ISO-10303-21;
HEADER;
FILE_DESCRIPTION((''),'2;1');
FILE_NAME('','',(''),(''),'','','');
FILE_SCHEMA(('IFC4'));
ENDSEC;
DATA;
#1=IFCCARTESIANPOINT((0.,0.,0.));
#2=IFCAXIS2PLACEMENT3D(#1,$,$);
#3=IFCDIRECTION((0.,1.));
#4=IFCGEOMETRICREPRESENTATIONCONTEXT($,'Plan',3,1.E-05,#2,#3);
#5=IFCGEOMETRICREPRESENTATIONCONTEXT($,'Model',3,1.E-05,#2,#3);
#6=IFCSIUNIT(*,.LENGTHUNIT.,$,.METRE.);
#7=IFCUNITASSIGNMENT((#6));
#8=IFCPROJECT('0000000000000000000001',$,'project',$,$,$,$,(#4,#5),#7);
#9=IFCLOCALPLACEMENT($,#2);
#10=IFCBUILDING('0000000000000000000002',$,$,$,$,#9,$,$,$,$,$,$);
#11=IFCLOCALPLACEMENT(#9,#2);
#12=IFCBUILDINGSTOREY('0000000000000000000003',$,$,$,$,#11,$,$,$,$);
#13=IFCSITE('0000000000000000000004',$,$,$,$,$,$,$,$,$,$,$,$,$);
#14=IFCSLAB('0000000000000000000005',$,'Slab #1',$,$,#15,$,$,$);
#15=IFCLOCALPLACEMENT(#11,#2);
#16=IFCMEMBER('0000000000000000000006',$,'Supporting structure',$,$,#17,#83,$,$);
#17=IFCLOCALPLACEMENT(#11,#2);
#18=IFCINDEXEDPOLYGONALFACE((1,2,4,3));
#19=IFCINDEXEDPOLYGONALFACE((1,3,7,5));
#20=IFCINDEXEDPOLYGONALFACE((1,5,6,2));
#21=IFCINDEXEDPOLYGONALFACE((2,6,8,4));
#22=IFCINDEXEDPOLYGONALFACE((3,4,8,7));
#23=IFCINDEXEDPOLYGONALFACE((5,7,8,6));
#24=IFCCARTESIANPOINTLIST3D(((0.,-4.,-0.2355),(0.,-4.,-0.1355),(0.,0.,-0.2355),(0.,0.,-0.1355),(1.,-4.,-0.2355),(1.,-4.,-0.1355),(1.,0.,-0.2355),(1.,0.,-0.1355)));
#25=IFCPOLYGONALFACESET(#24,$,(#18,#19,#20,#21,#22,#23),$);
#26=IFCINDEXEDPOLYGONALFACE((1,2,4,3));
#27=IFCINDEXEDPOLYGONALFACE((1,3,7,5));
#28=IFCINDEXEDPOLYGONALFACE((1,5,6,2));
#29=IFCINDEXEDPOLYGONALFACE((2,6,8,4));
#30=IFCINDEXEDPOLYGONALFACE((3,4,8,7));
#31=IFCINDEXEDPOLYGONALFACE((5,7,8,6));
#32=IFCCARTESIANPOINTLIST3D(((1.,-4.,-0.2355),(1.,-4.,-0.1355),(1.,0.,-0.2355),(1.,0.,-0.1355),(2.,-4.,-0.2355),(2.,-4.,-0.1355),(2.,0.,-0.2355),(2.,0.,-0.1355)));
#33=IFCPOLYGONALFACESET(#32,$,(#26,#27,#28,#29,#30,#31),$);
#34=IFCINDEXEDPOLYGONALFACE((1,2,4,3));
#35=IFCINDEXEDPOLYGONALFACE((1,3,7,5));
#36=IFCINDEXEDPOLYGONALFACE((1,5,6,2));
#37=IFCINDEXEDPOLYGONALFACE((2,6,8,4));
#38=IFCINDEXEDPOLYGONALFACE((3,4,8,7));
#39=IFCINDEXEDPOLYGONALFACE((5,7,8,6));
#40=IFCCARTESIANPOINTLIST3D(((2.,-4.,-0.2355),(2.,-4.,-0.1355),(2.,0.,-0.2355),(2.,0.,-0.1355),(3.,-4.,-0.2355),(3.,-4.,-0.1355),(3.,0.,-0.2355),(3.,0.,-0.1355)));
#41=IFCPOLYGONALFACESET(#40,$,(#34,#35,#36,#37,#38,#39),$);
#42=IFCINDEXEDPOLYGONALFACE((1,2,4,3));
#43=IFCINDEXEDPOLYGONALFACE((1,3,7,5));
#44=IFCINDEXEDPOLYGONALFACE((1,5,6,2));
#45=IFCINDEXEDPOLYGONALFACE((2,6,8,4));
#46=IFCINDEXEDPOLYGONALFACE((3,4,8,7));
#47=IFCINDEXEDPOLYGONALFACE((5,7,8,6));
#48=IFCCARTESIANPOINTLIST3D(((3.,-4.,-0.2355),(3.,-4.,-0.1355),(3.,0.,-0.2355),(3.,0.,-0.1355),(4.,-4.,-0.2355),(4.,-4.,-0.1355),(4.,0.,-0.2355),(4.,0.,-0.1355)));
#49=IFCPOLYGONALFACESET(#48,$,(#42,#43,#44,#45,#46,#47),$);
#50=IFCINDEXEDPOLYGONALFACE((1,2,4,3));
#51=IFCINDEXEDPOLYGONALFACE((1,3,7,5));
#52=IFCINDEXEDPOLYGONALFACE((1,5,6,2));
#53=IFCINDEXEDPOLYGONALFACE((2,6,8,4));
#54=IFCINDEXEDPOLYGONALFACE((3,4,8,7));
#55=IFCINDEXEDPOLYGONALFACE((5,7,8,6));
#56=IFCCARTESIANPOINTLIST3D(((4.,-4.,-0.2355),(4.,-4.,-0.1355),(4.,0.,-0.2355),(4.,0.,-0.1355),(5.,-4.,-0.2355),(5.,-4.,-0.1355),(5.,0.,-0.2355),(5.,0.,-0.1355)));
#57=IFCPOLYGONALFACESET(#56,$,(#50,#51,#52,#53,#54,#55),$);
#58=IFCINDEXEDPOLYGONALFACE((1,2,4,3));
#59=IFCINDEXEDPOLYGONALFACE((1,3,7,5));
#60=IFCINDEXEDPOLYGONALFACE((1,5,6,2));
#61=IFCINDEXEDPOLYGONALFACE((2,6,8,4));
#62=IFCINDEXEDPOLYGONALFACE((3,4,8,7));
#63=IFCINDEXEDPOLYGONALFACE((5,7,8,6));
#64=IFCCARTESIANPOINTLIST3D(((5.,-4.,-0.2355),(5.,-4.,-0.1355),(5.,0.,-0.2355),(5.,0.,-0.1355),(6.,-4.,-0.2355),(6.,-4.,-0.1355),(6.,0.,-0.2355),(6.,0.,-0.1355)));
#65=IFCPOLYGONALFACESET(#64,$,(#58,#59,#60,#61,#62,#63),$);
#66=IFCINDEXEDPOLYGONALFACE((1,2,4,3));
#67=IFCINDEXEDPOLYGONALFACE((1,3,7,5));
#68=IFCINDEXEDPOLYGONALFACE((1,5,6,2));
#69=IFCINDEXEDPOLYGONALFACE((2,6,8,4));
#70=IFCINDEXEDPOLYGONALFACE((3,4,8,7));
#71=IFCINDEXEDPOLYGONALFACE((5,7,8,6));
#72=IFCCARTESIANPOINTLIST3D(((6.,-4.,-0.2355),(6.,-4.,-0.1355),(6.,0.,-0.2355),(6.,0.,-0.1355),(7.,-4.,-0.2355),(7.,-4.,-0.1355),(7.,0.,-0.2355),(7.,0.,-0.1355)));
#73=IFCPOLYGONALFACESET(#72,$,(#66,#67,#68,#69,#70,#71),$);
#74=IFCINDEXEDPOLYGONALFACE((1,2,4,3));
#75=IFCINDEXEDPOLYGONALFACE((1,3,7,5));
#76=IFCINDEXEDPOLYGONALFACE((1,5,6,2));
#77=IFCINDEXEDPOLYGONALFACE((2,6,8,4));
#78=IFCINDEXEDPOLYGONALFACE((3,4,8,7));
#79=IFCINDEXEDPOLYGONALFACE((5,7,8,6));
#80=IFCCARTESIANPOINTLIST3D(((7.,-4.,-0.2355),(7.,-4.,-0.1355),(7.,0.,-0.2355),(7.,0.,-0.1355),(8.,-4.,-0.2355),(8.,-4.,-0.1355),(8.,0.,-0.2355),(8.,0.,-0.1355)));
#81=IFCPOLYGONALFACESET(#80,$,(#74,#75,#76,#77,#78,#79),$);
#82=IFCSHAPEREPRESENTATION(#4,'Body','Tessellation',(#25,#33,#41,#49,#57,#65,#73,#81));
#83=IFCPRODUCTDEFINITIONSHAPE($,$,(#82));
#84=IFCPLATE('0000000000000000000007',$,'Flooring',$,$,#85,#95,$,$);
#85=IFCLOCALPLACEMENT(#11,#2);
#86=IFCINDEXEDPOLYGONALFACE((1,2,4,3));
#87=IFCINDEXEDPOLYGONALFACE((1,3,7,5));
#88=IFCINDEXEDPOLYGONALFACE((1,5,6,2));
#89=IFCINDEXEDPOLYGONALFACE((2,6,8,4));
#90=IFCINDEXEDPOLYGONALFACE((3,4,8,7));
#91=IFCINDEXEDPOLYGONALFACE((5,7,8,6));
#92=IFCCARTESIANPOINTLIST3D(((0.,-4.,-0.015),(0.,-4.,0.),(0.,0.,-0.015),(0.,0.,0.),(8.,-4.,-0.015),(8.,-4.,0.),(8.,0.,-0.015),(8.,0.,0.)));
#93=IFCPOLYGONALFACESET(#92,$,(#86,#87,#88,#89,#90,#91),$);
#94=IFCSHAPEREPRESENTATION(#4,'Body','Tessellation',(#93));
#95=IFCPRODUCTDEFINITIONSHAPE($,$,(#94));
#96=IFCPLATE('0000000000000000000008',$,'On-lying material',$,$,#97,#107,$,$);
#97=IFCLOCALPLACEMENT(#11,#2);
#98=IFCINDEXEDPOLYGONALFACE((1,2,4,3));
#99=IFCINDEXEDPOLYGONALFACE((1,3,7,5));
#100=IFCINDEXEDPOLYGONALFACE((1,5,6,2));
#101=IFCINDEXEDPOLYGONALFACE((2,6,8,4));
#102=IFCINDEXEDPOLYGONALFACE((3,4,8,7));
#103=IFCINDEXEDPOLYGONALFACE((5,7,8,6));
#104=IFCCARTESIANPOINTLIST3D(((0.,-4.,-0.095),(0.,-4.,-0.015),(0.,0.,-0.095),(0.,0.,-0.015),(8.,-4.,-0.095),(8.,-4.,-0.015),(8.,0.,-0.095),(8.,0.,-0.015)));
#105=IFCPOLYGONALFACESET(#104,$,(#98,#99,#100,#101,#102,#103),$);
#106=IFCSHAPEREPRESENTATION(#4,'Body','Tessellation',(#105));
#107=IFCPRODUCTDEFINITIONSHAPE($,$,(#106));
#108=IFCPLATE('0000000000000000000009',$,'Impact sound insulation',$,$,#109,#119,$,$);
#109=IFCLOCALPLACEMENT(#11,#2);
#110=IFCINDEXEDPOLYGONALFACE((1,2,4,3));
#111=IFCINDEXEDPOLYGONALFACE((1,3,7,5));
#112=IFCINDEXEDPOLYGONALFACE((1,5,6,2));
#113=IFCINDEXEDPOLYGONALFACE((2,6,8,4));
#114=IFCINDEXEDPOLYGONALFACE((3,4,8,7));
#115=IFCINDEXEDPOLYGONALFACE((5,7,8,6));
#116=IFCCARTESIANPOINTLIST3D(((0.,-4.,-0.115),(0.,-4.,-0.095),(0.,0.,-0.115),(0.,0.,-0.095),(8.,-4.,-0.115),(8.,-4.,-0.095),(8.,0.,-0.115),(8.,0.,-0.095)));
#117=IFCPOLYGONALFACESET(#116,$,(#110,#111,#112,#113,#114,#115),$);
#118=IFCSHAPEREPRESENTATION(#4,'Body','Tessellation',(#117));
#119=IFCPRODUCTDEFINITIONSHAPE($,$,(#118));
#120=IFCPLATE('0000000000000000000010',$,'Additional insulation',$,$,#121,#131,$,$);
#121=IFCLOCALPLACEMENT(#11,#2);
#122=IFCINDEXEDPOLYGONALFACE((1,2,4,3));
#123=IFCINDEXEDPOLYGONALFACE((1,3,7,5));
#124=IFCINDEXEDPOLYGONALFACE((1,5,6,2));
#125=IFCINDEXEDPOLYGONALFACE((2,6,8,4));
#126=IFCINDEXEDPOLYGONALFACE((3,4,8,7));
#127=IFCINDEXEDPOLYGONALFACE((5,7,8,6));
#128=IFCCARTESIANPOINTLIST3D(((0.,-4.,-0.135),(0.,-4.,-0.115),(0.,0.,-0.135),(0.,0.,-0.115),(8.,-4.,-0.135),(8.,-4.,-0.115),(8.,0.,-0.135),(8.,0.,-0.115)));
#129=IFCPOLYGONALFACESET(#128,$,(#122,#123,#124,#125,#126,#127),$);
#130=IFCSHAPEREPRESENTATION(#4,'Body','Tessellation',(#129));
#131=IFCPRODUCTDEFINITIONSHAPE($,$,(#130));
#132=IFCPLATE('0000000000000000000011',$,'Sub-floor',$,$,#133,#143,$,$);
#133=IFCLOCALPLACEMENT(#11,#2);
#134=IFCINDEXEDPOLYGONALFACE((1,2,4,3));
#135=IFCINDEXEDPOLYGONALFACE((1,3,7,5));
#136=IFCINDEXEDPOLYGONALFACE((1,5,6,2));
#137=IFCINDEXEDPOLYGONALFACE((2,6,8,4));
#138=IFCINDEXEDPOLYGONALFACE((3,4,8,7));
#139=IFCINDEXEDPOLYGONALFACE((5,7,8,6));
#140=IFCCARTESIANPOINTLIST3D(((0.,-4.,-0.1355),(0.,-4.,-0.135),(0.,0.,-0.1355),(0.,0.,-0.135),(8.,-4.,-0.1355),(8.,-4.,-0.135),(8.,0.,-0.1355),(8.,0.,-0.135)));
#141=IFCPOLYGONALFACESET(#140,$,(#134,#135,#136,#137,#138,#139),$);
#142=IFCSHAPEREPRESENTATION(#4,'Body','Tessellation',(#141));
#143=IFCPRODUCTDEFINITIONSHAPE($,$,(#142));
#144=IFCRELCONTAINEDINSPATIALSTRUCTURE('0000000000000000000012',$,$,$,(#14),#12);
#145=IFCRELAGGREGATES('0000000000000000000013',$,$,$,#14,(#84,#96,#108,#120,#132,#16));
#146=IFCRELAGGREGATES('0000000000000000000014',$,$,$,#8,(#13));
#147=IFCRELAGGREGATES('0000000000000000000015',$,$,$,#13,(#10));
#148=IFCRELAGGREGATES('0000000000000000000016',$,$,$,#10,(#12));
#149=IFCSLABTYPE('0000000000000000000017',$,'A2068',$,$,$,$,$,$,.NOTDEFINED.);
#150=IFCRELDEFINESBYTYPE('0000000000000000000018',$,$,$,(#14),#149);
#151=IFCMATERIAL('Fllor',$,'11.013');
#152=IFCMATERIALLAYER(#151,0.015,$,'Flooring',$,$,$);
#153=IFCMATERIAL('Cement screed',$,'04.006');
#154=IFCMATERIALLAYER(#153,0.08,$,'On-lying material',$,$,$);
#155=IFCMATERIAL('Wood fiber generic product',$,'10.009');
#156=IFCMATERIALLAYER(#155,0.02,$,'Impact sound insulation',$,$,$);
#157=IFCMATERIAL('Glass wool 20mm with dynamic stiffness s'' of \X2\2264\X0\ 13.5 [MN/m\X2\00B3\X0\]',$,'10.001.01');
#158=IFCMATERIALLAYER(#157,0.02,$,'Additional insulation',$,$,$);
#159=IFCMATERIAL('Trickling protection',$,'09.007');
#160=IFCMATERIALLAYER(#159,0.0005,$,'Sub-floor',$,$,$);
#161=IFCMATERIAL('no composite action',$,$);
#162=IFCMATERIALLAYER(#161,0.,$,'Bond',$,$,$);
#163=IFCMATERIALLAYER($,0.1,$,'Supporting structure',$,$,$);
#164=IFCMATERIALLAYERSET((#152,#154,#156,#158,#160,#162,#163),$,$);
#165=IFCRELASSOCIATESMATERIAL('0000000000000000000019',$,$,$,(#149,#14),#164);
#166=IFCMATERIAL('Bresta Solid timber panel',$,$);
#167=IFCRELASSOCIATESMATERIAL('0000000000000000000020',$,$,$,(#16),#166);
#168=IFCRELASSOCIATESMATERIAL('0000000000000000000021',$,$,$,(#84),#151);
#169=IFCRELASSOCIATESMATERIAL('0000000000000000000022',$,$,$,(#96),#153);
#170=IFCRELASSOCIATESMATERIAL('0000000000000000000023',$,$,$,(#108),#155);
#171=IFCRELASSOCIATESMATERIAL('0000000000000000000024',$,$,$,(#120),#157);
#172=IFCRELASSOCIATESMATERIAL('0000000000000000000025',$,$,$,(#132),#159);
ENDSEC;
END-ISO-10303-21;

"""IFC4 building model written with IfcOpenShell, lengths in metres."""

from ifc_helpers import new_model, si_unit, direction, frame, frame_2d, origin, origin_with_axes, place, context, project, spatial, rectangle, extrude, material, layer, layer_set, type_object, element, aggregate, save


model = new_model("IFC4")

# Units and contexts
plan_context = context("Plan", 3, precision=1e-05, world=origin(), true_north=direction((0.0, 1.0)))
model_context = context("Model", 3, precision=1e-05, world=origin(), true_north=direction((0.0, 1.0)))
ifc_project = project(units=[si_unit("LENGTHUNIT", "METRE")], contexts=[plan_context, model_context])

# Site, building, storey
site = spatial("IfcSite", under=ifc_project)
building_placement = place(None, origin())
building = spatial("IfcBuilding", under=site, at=building_placement)
storey_placement = place(building_placement, origin())
storey = spatial("IfcBuildingStorey", under=building, at=storey_placement)

# Slab, member, plates
ifc_material_1 = material(Name="Fllor", Category="11.013")
ifc_layer_1 = layer(ifc_material_1, 0.015, Name="Flooring")
ifc_material_2 = material(Name="Cement screed", Category="04.006")
ifc_layer_2 = layer(ifc_material_2, 0.08, Name="On-lying material")
ifc_material_3 = material(Name="Wood fiber generic product", Category="10.009")
ifc_layer_3 = layer(ifc_material_3, 0.02, Name="Impact sound insulation")
ifc_material_4 = material(Name="Glass wool 20mm with dynamic stiffness s' of ≤ 13.5 [MN/m³]", Category="10.001.01")
ifc_layer_4 = layer(ifc_material_4, 0.02, Name="Additional insulation")
ifc_material_5 = material(Name="Trickling protection", Category="09.007")
ifc_layer_5 = layer(ifc_material_5, 0.0005, Name="Sub-floor")
ifc_material_6 = material(Name="no composite action")
ifc_layer_6 = layer(ifc_material_6, 0.0, Name="Bond")
ifc_layer_7 = layer(None, 0.1, Name="Supporting structure")
ifc_layer_set = layer_set([ifc_layer_1, ifc_layer_2, ifc_layer_3, ifc_layer_4, ifc_layer_5, ifc_layer_6, ifc_layer_7])
slab_type = type_object("IfcSlabType", Name="A2068", PredefinedType="NOTDEFINED", material=ifc_layer_set)
slab_placement = place(None, frame((0.0, 0.0, 0.0), z_axis=(0.0, 0.0, -1.0), x_axis=(1.0, 0.0, 0.0)))
slab = element("IfcSlab", 1, at=slab_placement, inside=storey, type_object=slab_type, material=ifc_layer_set, Name="Slab #1")
ifc_material_7 = material(Name="Bresta Solid timber panel")
member_placement = place(slab_placement, origin())
member = element("IfcMember", 2, at=member_placement, material=ifc_material_7, Name="Supporting structure", context=plan_context, shape_type="SweptSolid", body=[
    extrude(rectangle(XDim=1.0, YDim=0.1, at=frame_2d((0.5, 0.05), x_axis=(1.0, 0.0))), frame((0.0, 4.0, 0.1355), z_axis=(0.0, -1.0, 0.0), x_axis=(1.0, 0.0, 0.0)), (0.0, 0.0, 1.0), 4.0),
    extrude(rectangle(XDim=1.0, YDim=0.1, at=frame_2d((0.5, 0.05), x_axis=(1.0, 0.0))), frame((1.0, 4.0, 0.1355), z_axis=(0.0, -1.0, 0.0), x_axis=(1.0, 0.0, 0.0)), (0.0, 0.0, 1.0), 4.0),
    extrude(rectangle(XDim=1.0, YDim=0.1, at=frame_2d((0.5, 0.05), x_axis=(1.0, 0.0))), frame((2.0, 4.0, 0.1355), z_axis=(0.0, -1.0, 0.0), x_axis=(1.0, 0.0, 0.0)), (0.0, 0.0, 1.0), 4.0),
    extrude(rectangle(XDim=1.0, YDim=0.1, at=frame_2d((0.5, 0.05), x_axis=(1.0, 0.0))), frame((3.0, 4.0, 0.1355), z_axis=(0.0, -1.0, 0.0), x_axis=(1.0, 0.0, 0.0)), (0.0, 0.0, 1.0), 4.0),
    extrude(rectangle(XDim=1.0, YDim=0.1, at=frame_2d((0.5, 0.05), x_axis=(1.0, 0.0))), frame((4.0, 4.0, 0.1355), z_axis=(0.0, -1.0, 0.0), x_axis=(1.0, 0.0, 0.0)), (0.0, 0.0, 1.0), 4.0),
    extrude(rectangle(XDim=1.0, YDim=0.1, at=frame_2d((0.5, 0.05), x_axis=(1.0, 0.0))), frame((5.0, 4.0, 0.1355), z_axis=(0.0, -1.0, 0.0), x_axis=(1.0, 0.0, 0.0)), (0.0, 0.0, 1.0), 4.0),
    extrude(rectangle(XDim=1.0, YDim=0.1, at=frame_2d((0.5, 0.05), x_axis=(1.0, 0.0))), frame((6.0, 4.0, 0.1355), z_axis=(0.0, -1.0, 0.0), x_axis=(1.0, 0.0, 0.0)), (0.0, 0.0, 1.0), 4.0),
    extrude(rectangle(XDim=1.0, YDim=0.1, at=frame_2d((0.5, 0.05), x_axis=(1.0, 0.0))), frame((7.0, 4.0, 0.1355), z_axis=(0.0, -1.0, 0.0), x_axis=(1.0, 0.0, 0.0)), (0.0, 0.0, 1.0), 4.0),
])
plate_1_placement = place(slab_placement, origin())
plate_1 = element("IfcPlate", 3, at=plate_1_placement, material=ifc_material_1, Name="Flooring", context=plan_context, shape_type="SweptSolid", body=[
    extrude(rectangle(XDim=8.0, YDim=4.0, at=frame_2d((4.0, 2.0), x_axis=(1.0, 0.0))), origin_with_axes(), (0.0, 0.0, 1.0), 0.015),
])
plate_2_placement = place(slab_placement, origin())
plate_2 = element("IfcPlate", 4, at=plate_2_placement, material=ifc_material_2, Name="On-lying material", context=plan_context, shape_type="SweptSolid", body=[
    extrude(rectangle(XDim=8.0, YDim=4.0, at=frame_2d((4.0, 2.0), x_axis=(1.0, 0.0))), frame((0.0, 0.0, 0.015), z_axis=(0.0, 0.0, 1.0), x_axis=(1.0, 0.0, 0.0)), (0.0, 0.0, 1.0), 0.08),
])
plate_3_placement = place(slab_placement, origin())
plate_3 = element("IfcPlate", 5, at=plate_3_placement, material=ifc_material_3, Name="Impact sound insulation", context=plan_context, shape_type="SweptSolid", body=[
    extrude(rectangle(XDim=8.0, YDim=4.0, at=frame_2d((4.0, 2.0), x_axis=(1.0, 0.0))), frame((0.0, 0.0, 0.095), z_axis=(0.0, 0.0, 1.0), x_axis=(1.0, 0.0, 0.0)), (0.0, 0.0, 1.0), 0.02),
])
plate_4_placement = place(slab_placement, origin())
plate_4 = element("IfcPlate", 6, at=plate_4_placement, material=ifc_material_4, Name="Additional insulation", context=plan_context, shape_type="SweptSolid", body=[
    extrude(rectangle(XDim=8.0, YDim=4.0, at=frame_2d((4.0, 2.0), x_axis=(1.0, 0.0))), frame((0.0, 0.0, 0.115), z_axis=(0.0, 0.0, 1.0), x_axis=(1.0, 0.0, 0.0)), (0.0, 0.0, 1.0), 0.02),
])
plate_5_placement = place(slab_placement, origin())
plate_5 = element("IfcPlate", 7, at=plate_5_placement, material=ifc_material_5, Name="Sub-floor", context=plan_context, shape_type="SweptSolid", body=[
    extrude(rectangle(XDim=8.0, YDim=4.0, at=frame_2d((4.0, 2.0), x_axis=(1.0, 0.0))), frame((0.0, 0.0, 0.135), z_axis=(0.0, 0.0, 1.0), x_axis=(1.0, 0.0, 0.0)), (0.0, 0.0, 1.0), 0.0005),
])
aggregate(slab, [plate_1, plate_2, plate_3, plate_4, plate_5, member])

save(model, "model.ifc")
